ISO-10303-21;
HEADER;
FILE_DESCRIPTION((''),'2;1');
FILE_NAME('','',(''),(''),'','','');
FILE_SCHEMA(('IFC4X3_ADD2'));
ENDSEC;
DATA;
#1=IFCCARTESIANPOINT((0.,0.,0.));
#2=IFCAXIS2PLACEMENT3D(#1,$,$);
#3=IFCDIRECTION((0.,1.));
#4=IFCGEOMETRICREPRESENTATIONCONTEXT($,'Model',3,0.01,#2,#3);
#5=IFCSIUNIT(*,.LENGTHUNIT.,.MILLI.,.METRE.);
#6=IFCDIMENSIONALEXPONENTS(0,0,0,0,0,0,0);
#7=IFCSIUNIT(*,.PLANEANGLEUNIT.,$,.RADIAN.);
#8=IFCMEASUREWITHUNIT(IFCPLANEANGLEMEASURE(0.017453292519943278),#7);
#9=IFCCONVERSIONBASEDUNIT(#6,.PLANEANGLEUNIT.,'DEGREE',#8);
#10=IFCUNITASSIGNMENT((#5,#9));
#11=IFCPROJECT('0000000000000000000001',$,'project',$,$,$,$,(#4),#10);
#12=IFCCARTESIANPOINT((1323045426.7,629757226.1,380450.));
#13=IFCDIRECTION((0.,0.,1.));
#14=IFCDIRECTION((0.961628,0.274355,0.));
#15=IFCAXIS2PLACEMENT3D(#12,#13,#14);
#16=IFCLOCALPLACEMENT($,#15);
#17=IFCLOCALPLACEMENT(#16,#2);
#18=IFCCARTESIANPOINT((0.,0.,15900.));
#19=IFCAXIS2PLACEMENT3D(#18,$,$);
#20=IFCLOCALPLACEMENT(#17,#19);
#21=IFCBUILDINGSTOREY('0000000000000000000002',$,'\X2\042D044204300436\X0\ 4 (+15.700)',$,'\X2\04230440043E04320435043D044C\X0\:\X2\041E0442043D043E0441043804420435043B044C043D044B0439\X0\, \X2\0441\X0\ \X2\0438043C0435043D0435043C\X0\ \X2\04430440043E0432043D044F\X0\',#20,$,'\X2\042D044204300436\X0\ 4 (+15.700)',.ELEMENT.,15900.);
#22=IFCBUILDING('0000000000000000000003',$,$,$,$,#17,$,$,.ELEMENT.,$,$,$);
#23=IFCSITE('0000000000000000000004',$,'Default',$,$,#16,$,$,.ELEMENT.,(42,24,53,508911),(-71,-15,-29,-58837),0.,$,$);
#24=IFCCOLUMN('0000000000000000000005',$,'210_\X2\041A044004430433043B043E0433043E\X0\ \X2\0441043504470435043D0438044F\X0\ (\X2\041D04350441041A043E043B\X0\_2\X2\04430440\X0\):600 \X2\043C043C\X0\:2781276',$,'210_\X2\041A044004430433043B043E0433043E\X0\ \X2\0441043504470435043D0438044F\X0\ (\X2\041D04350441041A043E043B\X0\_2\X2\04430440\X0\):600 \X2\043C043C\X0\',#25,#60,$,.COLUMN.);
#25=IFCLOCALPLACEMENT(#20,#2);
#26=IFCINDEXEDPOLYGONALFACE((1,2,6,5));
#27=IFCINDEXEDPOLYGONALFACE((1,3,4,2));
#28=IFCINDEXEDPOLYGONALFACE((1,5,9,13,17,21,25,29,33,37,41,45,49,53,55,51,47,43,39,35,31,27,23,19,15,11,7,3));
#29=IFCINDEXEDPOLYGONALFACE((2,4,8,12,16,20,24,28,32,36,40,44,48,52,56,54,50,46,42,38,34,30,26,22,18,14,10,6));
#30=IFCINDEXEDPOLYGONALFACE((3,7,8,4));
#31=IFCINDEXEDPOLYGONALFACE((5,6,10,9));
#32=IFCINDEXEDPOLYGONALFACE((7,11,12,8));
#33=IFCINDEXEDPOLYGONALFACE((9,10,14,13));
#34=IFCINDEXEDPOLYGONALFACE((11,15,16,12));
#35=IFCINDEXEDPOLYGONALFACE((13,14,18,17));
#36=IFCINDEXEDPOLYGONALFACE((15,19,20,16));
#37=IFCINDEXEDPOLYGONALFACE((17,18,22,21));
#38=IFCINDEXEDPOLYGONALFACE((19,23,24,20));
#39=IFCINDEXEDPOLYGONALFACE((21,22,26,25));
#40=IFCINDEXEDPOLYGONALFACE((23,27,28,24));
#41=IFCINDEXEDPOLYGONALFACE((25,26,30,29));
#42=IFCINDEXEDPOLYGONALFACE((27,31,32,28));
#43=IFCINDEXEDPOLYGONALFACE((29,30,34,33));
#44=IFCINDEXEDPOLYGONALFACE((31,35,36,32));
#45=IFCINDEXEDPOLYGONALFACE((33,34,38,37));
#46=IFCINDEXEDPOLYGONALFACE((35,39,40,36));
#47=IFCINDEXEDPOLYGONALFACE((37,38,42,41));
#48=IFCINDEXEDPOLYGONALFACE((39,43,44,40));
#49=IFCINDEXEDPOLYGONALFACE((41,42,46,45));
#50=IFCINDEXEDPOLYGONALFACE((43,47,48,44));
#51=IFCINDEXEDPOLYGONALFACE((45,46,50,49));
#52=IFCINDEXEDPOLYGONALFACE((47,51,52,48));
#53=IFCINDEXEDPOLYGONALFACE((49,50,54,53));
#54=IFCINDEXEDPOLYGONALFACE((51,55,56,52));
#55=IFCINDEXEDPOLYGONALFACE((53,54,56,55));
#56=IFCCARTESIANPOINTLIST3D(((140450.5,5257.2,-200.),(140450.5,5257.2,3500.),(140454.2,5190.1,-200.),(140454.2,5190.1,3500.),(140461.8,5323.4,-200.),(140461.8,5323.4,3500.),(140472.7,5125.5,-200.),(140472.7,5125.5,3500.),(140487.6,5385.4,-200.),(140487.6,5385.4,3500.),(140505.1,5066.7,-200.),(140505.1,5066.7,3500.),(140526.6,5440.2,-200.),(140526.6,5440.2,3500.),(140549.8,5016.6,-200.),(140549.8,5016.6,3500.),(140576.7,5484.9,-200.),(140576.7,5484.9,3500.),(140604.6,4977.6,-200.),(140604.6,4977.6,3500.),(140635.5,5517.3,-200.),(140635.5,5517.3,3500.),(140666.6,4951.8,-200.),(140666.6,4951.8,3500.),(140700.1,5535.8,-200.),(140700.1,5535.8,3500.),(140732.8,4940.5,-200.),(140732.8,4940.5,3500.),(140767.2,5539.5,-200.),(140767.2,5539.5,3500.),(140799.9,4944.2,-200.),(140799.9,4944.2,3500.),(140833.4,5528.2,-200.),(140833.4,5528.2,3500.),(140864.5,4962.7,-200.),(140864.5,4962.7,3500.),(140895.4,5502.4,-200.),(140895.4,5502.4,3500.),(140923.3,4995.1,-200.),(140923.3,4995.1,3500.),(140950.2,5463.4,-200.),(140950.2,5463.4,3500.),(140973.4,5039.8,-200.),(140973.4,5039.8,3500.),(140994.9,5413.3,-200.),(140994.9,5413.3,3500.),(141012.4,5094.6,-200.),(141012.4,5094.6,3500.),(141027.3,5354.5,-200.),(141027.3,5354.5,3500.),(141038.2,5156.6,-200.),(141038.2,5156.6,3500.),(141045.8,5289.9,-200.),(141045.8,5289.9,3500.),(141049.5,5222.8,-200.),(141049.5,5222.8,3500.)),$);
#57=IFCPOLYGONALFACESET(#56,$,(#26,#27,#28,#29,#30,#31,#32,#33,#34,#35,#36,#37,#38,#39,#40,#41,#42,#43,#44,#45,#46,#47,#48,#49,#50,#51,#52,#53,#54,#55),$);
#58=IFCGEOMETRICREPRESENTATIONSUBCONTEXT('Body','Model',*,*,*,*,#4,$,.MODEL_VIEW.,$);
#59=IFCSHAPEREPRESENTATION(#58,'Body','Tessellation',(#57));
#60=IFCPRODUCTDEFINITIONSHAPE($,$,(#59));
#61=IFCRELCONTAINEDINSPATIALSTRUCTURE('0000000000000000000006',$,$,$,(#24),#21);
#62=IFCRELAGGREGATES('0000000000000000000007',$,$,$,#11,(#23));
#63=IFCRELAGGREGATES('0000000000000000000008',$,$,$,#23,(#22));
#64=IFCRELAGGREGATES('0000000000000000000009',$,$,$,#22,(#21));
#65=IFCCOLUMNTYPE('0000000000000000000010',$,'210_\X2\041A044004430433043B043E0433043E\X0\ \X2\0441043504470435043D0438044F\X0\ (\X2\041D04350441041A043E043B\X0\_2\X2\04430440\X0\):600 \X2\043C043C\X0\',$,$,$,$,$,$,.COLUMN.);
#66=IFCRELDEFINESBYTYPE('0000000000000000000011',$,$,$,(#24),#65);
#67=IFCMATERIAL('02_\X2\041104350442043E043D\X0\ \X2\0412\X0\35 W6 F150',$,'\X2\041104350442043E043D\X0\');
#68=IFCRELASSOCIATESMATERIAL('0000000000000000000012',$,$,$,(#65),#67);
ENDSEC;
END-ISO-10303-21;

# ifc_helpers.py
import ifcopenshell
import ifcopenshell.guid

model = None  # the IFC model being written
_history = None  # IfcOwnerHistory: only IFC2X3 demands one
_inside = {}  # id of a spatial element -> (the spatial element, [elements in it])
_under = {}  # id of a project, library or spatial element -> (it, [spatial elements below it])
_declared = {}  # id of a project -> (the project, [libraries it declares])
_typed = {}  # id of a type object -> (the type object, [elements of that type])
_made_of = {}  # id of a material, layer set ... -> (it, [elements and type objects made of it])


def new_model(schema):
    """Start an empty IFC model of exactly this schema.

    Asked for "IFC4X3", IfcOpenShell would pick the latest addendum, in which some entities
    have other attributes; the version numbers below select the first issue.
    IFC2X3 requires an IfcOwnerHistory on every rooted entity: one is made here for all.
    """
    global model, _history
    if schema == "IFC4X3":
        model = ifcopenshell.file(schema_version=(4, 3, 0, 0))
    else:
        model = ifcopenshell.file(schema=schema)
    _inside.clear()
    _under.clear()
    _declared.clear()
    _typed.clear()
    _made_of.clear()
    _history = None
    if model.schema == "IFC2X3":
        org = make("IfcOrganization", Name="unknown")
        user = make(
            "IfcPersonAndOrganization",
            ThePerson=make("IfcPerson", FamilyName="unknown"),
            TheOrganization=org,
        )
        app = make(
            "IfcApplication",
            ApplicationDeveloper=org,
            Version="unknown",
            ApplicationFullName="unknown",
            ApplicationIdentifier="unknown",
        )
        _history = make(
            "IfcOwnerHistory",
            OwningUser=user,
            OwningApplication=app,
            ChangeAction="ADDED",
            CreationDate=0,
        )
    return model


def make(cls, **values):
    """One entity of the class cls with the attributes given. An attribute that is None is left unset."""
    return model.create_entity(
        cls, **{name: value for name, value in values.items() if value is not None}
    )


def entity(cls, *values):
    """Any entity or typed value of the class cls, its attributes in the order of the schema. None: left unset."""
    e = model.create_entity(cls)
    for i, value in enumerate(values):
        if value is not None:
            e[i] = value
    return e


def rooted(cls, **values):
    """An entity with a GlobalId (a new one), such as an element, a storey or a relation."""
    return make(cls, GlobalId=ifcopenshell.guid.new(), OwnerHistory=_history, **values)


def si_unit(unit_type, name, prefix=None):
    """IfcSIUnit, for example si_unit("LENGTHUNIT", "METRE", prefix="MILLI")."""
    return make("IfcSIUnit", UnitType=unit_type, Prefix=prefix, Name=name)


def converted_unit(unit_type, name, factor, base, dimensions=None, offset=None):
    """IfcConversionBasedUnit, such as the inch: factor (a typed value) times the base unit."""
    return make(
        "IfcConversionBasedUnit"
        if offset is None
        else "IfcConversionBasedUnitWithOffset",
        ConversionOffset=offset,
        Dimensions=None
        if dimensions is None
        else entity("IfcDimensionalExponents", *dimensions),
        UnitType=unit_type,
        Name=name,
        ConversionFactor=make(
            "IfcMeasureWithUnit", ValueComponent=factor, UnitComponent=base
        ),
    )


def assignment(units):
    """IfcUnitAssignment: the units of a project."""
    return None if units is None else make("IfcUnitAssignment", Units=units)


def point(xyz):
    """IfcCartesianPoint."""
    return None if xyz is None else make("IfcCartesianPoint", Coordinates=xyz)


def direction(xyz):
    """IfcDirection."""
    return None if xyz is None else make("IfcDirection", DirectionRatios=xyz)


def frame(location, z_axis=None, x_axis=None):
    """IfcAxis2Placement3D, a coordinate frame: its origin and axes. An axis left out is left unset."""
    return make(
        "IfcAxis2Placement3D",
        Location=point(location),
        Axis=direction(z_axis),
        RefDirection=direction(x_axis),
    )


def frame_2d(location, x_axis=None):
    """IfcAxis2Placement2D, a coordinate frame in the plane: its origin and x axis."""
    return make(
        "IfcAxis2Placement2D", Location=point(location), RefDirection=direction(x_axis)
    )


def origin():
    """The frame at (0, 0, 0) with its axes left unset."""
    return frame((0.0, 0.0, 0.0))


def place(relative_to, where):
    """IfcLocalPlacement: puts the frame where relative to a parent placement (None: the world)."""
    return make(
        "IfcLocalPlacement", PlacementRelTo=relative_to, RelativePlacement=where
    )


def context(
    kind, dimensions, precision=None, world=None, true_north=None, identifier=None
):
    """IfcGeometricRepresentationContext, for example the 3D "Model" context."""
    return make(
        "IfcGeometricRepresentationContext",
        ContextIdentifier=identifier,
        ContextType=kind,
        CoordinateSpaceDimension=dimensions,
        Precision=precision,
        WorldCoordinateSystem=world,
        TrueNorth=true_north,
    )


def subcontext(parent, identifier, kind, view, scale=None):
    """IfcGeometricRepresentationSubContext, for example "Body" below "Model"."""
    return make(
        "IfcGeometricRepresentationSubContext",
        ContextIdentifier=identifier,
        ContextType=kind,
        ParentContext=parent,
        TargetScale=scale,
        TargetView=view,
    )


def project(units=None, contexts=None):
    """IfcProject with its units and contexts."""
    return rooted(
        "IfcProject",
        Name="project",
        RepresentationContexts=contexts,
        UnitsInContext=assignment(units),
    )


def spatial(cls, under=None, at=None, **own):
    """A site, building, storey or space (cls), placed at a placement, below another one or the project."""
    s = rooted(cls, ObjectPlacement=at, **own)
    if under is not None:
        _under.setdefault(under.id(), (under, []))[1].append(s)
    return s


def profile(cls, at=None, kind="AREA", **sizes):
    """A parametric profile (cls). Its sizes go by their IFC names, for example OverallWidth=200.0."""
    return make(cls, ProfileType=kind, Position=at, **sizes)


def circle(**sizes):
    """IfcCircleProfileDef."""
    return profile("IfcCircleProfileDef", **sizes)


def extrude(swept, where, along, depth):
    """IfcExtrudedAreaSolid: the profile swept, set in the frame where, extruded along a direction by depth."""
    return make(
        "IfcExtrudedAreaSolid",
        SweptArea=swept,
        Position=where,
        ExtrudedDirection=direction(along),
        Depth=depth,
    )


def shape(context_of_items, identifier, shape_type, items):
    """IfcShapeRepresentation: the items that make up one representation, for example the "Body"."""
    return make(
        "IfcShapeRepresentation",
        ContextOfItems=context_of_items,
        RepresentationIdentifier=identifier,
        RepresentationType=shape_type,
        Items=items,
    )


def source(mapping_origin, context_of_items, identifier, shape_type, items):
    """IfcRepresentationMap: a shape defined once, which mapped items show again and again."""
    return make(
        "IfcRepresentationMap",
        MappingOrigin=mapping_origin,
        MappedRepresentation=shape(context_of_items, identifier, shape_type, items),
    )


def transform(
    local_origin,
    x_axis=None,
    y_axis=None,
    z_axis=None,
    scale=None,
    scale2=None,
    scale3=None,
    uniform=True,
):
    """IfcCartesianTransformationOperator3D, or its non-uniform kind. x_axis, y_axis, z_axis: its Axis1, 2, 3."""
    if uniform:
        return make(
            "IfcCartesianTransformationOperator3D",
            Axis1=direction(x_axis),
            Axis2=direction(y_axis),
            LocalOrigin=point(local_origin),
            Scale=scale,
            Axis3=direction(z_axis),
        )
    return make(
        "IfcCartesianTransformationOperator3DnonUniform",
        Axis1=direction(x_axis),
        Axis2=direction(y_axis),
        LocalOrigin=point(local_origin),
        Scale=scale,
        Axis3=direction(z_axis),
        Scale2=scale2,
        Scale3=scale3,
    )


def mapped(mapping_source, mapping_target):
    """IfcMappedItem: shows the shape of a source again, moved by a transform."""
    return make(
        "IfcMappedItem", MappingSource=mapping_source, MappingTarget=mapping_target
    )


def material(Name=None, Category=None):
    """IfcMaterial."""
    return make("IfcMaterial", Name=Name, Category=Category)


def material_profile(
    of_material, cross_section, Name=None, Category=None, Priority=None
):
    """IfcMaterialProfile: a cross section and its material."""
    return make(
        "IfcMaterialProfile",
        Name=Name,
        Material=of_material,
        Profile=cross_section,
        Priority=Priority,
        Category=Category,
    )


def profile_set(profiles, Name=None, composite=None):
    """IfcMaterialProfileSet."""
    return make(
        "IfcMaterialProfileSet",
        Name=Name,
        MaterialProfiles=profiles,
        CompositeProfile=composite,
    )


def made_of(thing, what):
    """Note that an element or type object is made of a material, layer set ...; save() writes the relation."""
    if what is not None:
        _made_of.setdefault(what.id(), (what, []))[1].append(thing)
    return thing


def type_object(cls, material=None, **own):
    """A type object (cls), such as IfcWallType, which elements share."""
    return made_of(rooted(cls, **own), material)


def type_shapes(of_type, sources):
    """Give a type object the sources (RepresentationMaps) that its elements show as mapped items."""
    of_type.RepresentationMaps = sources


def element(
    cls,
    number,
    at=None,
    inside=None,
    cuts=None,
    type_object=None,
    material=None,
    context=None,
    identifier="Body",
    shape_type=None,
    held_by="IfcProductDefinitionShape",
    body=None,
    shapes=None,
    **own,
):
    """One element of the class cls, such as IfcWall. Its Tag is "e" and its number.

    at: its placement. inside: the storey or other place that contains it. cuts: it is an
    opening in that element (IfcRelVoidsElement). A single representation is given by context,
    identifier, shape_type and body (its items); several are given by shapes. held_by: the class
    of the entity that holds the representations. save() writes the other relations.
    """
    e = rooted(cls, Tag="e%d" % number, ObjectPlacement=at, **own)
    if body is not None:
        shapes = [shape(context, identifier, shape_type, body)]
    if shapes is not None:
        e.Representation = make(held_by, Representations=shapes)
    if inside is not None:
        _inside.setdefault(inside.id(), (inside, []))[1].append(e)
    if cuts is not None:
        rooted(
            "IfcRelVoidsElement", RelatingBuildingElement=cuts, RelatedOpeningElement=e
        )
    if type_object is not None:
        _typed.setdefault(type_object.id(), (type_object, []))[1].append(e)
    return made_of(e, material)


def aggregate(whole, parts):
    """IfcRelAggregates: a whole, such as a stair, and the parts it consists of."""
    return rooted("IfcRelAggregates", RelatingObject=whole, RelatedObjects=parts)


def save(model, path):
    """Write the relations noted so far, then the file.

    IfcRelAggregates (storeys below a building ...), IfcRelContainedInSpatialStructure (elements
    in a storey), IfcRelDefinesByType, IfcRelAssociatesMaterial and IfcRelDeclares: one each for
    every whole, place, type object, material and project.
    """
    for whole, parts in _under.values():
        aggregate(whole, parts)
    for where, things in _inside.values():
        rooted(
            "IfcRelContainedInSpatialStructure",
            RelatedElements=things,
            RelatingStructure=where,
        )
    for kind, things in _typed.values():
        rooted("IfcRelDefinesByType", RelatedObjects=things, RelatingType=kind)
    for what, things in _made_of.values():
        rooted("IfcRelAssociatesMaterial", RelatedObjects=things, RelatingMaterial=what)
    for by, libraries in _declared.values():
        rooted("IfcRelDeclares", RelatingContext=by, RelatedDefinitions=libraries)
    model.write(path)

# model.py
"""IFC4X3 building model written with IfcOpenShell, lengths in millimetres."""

from ifc_helpers import new_model, entity, si_unit, converted_unit, direction, frame, frame_2d, origin, place, context, subcontext, project, spatial, circle, extrude, source, transform, mapped, material, material_profile, profile_set, type_object, type_shapes, element, save


model = new_model("IFC4X3")

# Units and contexts
model_context = context("Model", 3, precision=0.01, world=origin(), true_north=direction((0.0, 1.0)))
body_context = subcontext(model_context, "Body", "Model", "MODEL_VIEW")
ifc_project = project(units=[si_unit("LENGTHUNIT", "METRE", prefix="MILLI"), converted_unit("PLANEANGLEUNIT", "DEGREE", entity("IfcPlaneAngleMeasure", 0.017453292519943278), si_unit("PLANEANGLEUNIT", "RADIAN"), dimensions=[0, 0, 0, 0, 0, 0, 0])], contexts=[model_context])

# Site, building, storey
site_placement = place(None, frame((1323045426.7, 629757226.1, 380450.0), z_axis=(0.0, 0.0, 1.0), x_axis=(0.961628, 0.274355, 0.0)))
site = spatial("IfcSite", under=ifc_project, at=site_placement, Name="Default", CompositionType="ELEMENT", RefLatitude=(42, 24, 53, 508911), RefLongitude=(-71, -15, -29, -58837), RefElevation=0.0)
building_placement = place(site_placement, origin())
building = spatial("IfcBuilding", under=site, at=building_placement, CompositionType="ELEMENT")
storey_placement = place(building_placement, frame((0.0, 0.0, 15900.0)))
storey = spatial("IfcBuildingStorey", under=building, at=storey_placement, Name="Этаж 4 (+15.700)", ObjectType="Уровень:Относительный, с именем уровня", LongName="Этаж 4 (+15.700)", CompositionType="ELEMENT", Elevation=15900.0)

# Column
ifc_material = material(Name="02_Бетон В35 W6 F150", Category="Бетон")
ifc_material_profile_1 = material_profile(ifc_material, circle(Radius=300.0, at=frame_2d((0.0, 0.0), x_axis=(1.0, 0.0))), Name="600 мм")
ifc_profile_set_1 = profile_set([ifc_material_profile_1], Name="600 мм")
column_type_1 = type_object("IfcColumnType", Name="210_Круглого сечения (НесКол_2ур):600 мм", PredefinedType="COLUMN", material=ifc_profile_set_1)
shared_shape_1 = source(origin(), body_context, "Body", "SweptSolid", [
    extrude(circle(Radius=300.0, at=frame_2d((0.0, 0.0), x_axis=(1.0, 0.0))), frame((140750.0, 5240.0, 15700.0), z_axis=(0.0, 0.0, 1.0), x_axis=(0.87462, -0.48481, 0.0)), (0.0, 0.0, 1.0), 3700.0),
])
type_shapes(column_type_1, [shared_shape_1])
column_1_placement = place(storey_placement, frame((0.0, 0.0, -15900.0)))
element("IfcColumn", 1, at=column_1_placement, inside=storey, type_object=column_type_1, Name="210_Круглого сечения (НесКол_2ур):600 мм:2781276", ObjectType="210_Круглого сечения (НесКол_2ур):600 мм", PredefinedType="COLUMN", context=body_context, shape_type="MappedRepresentation", body=[
    mapped(shared_shape_1, transform((0.0, 0.0, 0.0), scale=1.0)),
])

save(model, "model.ifc")
